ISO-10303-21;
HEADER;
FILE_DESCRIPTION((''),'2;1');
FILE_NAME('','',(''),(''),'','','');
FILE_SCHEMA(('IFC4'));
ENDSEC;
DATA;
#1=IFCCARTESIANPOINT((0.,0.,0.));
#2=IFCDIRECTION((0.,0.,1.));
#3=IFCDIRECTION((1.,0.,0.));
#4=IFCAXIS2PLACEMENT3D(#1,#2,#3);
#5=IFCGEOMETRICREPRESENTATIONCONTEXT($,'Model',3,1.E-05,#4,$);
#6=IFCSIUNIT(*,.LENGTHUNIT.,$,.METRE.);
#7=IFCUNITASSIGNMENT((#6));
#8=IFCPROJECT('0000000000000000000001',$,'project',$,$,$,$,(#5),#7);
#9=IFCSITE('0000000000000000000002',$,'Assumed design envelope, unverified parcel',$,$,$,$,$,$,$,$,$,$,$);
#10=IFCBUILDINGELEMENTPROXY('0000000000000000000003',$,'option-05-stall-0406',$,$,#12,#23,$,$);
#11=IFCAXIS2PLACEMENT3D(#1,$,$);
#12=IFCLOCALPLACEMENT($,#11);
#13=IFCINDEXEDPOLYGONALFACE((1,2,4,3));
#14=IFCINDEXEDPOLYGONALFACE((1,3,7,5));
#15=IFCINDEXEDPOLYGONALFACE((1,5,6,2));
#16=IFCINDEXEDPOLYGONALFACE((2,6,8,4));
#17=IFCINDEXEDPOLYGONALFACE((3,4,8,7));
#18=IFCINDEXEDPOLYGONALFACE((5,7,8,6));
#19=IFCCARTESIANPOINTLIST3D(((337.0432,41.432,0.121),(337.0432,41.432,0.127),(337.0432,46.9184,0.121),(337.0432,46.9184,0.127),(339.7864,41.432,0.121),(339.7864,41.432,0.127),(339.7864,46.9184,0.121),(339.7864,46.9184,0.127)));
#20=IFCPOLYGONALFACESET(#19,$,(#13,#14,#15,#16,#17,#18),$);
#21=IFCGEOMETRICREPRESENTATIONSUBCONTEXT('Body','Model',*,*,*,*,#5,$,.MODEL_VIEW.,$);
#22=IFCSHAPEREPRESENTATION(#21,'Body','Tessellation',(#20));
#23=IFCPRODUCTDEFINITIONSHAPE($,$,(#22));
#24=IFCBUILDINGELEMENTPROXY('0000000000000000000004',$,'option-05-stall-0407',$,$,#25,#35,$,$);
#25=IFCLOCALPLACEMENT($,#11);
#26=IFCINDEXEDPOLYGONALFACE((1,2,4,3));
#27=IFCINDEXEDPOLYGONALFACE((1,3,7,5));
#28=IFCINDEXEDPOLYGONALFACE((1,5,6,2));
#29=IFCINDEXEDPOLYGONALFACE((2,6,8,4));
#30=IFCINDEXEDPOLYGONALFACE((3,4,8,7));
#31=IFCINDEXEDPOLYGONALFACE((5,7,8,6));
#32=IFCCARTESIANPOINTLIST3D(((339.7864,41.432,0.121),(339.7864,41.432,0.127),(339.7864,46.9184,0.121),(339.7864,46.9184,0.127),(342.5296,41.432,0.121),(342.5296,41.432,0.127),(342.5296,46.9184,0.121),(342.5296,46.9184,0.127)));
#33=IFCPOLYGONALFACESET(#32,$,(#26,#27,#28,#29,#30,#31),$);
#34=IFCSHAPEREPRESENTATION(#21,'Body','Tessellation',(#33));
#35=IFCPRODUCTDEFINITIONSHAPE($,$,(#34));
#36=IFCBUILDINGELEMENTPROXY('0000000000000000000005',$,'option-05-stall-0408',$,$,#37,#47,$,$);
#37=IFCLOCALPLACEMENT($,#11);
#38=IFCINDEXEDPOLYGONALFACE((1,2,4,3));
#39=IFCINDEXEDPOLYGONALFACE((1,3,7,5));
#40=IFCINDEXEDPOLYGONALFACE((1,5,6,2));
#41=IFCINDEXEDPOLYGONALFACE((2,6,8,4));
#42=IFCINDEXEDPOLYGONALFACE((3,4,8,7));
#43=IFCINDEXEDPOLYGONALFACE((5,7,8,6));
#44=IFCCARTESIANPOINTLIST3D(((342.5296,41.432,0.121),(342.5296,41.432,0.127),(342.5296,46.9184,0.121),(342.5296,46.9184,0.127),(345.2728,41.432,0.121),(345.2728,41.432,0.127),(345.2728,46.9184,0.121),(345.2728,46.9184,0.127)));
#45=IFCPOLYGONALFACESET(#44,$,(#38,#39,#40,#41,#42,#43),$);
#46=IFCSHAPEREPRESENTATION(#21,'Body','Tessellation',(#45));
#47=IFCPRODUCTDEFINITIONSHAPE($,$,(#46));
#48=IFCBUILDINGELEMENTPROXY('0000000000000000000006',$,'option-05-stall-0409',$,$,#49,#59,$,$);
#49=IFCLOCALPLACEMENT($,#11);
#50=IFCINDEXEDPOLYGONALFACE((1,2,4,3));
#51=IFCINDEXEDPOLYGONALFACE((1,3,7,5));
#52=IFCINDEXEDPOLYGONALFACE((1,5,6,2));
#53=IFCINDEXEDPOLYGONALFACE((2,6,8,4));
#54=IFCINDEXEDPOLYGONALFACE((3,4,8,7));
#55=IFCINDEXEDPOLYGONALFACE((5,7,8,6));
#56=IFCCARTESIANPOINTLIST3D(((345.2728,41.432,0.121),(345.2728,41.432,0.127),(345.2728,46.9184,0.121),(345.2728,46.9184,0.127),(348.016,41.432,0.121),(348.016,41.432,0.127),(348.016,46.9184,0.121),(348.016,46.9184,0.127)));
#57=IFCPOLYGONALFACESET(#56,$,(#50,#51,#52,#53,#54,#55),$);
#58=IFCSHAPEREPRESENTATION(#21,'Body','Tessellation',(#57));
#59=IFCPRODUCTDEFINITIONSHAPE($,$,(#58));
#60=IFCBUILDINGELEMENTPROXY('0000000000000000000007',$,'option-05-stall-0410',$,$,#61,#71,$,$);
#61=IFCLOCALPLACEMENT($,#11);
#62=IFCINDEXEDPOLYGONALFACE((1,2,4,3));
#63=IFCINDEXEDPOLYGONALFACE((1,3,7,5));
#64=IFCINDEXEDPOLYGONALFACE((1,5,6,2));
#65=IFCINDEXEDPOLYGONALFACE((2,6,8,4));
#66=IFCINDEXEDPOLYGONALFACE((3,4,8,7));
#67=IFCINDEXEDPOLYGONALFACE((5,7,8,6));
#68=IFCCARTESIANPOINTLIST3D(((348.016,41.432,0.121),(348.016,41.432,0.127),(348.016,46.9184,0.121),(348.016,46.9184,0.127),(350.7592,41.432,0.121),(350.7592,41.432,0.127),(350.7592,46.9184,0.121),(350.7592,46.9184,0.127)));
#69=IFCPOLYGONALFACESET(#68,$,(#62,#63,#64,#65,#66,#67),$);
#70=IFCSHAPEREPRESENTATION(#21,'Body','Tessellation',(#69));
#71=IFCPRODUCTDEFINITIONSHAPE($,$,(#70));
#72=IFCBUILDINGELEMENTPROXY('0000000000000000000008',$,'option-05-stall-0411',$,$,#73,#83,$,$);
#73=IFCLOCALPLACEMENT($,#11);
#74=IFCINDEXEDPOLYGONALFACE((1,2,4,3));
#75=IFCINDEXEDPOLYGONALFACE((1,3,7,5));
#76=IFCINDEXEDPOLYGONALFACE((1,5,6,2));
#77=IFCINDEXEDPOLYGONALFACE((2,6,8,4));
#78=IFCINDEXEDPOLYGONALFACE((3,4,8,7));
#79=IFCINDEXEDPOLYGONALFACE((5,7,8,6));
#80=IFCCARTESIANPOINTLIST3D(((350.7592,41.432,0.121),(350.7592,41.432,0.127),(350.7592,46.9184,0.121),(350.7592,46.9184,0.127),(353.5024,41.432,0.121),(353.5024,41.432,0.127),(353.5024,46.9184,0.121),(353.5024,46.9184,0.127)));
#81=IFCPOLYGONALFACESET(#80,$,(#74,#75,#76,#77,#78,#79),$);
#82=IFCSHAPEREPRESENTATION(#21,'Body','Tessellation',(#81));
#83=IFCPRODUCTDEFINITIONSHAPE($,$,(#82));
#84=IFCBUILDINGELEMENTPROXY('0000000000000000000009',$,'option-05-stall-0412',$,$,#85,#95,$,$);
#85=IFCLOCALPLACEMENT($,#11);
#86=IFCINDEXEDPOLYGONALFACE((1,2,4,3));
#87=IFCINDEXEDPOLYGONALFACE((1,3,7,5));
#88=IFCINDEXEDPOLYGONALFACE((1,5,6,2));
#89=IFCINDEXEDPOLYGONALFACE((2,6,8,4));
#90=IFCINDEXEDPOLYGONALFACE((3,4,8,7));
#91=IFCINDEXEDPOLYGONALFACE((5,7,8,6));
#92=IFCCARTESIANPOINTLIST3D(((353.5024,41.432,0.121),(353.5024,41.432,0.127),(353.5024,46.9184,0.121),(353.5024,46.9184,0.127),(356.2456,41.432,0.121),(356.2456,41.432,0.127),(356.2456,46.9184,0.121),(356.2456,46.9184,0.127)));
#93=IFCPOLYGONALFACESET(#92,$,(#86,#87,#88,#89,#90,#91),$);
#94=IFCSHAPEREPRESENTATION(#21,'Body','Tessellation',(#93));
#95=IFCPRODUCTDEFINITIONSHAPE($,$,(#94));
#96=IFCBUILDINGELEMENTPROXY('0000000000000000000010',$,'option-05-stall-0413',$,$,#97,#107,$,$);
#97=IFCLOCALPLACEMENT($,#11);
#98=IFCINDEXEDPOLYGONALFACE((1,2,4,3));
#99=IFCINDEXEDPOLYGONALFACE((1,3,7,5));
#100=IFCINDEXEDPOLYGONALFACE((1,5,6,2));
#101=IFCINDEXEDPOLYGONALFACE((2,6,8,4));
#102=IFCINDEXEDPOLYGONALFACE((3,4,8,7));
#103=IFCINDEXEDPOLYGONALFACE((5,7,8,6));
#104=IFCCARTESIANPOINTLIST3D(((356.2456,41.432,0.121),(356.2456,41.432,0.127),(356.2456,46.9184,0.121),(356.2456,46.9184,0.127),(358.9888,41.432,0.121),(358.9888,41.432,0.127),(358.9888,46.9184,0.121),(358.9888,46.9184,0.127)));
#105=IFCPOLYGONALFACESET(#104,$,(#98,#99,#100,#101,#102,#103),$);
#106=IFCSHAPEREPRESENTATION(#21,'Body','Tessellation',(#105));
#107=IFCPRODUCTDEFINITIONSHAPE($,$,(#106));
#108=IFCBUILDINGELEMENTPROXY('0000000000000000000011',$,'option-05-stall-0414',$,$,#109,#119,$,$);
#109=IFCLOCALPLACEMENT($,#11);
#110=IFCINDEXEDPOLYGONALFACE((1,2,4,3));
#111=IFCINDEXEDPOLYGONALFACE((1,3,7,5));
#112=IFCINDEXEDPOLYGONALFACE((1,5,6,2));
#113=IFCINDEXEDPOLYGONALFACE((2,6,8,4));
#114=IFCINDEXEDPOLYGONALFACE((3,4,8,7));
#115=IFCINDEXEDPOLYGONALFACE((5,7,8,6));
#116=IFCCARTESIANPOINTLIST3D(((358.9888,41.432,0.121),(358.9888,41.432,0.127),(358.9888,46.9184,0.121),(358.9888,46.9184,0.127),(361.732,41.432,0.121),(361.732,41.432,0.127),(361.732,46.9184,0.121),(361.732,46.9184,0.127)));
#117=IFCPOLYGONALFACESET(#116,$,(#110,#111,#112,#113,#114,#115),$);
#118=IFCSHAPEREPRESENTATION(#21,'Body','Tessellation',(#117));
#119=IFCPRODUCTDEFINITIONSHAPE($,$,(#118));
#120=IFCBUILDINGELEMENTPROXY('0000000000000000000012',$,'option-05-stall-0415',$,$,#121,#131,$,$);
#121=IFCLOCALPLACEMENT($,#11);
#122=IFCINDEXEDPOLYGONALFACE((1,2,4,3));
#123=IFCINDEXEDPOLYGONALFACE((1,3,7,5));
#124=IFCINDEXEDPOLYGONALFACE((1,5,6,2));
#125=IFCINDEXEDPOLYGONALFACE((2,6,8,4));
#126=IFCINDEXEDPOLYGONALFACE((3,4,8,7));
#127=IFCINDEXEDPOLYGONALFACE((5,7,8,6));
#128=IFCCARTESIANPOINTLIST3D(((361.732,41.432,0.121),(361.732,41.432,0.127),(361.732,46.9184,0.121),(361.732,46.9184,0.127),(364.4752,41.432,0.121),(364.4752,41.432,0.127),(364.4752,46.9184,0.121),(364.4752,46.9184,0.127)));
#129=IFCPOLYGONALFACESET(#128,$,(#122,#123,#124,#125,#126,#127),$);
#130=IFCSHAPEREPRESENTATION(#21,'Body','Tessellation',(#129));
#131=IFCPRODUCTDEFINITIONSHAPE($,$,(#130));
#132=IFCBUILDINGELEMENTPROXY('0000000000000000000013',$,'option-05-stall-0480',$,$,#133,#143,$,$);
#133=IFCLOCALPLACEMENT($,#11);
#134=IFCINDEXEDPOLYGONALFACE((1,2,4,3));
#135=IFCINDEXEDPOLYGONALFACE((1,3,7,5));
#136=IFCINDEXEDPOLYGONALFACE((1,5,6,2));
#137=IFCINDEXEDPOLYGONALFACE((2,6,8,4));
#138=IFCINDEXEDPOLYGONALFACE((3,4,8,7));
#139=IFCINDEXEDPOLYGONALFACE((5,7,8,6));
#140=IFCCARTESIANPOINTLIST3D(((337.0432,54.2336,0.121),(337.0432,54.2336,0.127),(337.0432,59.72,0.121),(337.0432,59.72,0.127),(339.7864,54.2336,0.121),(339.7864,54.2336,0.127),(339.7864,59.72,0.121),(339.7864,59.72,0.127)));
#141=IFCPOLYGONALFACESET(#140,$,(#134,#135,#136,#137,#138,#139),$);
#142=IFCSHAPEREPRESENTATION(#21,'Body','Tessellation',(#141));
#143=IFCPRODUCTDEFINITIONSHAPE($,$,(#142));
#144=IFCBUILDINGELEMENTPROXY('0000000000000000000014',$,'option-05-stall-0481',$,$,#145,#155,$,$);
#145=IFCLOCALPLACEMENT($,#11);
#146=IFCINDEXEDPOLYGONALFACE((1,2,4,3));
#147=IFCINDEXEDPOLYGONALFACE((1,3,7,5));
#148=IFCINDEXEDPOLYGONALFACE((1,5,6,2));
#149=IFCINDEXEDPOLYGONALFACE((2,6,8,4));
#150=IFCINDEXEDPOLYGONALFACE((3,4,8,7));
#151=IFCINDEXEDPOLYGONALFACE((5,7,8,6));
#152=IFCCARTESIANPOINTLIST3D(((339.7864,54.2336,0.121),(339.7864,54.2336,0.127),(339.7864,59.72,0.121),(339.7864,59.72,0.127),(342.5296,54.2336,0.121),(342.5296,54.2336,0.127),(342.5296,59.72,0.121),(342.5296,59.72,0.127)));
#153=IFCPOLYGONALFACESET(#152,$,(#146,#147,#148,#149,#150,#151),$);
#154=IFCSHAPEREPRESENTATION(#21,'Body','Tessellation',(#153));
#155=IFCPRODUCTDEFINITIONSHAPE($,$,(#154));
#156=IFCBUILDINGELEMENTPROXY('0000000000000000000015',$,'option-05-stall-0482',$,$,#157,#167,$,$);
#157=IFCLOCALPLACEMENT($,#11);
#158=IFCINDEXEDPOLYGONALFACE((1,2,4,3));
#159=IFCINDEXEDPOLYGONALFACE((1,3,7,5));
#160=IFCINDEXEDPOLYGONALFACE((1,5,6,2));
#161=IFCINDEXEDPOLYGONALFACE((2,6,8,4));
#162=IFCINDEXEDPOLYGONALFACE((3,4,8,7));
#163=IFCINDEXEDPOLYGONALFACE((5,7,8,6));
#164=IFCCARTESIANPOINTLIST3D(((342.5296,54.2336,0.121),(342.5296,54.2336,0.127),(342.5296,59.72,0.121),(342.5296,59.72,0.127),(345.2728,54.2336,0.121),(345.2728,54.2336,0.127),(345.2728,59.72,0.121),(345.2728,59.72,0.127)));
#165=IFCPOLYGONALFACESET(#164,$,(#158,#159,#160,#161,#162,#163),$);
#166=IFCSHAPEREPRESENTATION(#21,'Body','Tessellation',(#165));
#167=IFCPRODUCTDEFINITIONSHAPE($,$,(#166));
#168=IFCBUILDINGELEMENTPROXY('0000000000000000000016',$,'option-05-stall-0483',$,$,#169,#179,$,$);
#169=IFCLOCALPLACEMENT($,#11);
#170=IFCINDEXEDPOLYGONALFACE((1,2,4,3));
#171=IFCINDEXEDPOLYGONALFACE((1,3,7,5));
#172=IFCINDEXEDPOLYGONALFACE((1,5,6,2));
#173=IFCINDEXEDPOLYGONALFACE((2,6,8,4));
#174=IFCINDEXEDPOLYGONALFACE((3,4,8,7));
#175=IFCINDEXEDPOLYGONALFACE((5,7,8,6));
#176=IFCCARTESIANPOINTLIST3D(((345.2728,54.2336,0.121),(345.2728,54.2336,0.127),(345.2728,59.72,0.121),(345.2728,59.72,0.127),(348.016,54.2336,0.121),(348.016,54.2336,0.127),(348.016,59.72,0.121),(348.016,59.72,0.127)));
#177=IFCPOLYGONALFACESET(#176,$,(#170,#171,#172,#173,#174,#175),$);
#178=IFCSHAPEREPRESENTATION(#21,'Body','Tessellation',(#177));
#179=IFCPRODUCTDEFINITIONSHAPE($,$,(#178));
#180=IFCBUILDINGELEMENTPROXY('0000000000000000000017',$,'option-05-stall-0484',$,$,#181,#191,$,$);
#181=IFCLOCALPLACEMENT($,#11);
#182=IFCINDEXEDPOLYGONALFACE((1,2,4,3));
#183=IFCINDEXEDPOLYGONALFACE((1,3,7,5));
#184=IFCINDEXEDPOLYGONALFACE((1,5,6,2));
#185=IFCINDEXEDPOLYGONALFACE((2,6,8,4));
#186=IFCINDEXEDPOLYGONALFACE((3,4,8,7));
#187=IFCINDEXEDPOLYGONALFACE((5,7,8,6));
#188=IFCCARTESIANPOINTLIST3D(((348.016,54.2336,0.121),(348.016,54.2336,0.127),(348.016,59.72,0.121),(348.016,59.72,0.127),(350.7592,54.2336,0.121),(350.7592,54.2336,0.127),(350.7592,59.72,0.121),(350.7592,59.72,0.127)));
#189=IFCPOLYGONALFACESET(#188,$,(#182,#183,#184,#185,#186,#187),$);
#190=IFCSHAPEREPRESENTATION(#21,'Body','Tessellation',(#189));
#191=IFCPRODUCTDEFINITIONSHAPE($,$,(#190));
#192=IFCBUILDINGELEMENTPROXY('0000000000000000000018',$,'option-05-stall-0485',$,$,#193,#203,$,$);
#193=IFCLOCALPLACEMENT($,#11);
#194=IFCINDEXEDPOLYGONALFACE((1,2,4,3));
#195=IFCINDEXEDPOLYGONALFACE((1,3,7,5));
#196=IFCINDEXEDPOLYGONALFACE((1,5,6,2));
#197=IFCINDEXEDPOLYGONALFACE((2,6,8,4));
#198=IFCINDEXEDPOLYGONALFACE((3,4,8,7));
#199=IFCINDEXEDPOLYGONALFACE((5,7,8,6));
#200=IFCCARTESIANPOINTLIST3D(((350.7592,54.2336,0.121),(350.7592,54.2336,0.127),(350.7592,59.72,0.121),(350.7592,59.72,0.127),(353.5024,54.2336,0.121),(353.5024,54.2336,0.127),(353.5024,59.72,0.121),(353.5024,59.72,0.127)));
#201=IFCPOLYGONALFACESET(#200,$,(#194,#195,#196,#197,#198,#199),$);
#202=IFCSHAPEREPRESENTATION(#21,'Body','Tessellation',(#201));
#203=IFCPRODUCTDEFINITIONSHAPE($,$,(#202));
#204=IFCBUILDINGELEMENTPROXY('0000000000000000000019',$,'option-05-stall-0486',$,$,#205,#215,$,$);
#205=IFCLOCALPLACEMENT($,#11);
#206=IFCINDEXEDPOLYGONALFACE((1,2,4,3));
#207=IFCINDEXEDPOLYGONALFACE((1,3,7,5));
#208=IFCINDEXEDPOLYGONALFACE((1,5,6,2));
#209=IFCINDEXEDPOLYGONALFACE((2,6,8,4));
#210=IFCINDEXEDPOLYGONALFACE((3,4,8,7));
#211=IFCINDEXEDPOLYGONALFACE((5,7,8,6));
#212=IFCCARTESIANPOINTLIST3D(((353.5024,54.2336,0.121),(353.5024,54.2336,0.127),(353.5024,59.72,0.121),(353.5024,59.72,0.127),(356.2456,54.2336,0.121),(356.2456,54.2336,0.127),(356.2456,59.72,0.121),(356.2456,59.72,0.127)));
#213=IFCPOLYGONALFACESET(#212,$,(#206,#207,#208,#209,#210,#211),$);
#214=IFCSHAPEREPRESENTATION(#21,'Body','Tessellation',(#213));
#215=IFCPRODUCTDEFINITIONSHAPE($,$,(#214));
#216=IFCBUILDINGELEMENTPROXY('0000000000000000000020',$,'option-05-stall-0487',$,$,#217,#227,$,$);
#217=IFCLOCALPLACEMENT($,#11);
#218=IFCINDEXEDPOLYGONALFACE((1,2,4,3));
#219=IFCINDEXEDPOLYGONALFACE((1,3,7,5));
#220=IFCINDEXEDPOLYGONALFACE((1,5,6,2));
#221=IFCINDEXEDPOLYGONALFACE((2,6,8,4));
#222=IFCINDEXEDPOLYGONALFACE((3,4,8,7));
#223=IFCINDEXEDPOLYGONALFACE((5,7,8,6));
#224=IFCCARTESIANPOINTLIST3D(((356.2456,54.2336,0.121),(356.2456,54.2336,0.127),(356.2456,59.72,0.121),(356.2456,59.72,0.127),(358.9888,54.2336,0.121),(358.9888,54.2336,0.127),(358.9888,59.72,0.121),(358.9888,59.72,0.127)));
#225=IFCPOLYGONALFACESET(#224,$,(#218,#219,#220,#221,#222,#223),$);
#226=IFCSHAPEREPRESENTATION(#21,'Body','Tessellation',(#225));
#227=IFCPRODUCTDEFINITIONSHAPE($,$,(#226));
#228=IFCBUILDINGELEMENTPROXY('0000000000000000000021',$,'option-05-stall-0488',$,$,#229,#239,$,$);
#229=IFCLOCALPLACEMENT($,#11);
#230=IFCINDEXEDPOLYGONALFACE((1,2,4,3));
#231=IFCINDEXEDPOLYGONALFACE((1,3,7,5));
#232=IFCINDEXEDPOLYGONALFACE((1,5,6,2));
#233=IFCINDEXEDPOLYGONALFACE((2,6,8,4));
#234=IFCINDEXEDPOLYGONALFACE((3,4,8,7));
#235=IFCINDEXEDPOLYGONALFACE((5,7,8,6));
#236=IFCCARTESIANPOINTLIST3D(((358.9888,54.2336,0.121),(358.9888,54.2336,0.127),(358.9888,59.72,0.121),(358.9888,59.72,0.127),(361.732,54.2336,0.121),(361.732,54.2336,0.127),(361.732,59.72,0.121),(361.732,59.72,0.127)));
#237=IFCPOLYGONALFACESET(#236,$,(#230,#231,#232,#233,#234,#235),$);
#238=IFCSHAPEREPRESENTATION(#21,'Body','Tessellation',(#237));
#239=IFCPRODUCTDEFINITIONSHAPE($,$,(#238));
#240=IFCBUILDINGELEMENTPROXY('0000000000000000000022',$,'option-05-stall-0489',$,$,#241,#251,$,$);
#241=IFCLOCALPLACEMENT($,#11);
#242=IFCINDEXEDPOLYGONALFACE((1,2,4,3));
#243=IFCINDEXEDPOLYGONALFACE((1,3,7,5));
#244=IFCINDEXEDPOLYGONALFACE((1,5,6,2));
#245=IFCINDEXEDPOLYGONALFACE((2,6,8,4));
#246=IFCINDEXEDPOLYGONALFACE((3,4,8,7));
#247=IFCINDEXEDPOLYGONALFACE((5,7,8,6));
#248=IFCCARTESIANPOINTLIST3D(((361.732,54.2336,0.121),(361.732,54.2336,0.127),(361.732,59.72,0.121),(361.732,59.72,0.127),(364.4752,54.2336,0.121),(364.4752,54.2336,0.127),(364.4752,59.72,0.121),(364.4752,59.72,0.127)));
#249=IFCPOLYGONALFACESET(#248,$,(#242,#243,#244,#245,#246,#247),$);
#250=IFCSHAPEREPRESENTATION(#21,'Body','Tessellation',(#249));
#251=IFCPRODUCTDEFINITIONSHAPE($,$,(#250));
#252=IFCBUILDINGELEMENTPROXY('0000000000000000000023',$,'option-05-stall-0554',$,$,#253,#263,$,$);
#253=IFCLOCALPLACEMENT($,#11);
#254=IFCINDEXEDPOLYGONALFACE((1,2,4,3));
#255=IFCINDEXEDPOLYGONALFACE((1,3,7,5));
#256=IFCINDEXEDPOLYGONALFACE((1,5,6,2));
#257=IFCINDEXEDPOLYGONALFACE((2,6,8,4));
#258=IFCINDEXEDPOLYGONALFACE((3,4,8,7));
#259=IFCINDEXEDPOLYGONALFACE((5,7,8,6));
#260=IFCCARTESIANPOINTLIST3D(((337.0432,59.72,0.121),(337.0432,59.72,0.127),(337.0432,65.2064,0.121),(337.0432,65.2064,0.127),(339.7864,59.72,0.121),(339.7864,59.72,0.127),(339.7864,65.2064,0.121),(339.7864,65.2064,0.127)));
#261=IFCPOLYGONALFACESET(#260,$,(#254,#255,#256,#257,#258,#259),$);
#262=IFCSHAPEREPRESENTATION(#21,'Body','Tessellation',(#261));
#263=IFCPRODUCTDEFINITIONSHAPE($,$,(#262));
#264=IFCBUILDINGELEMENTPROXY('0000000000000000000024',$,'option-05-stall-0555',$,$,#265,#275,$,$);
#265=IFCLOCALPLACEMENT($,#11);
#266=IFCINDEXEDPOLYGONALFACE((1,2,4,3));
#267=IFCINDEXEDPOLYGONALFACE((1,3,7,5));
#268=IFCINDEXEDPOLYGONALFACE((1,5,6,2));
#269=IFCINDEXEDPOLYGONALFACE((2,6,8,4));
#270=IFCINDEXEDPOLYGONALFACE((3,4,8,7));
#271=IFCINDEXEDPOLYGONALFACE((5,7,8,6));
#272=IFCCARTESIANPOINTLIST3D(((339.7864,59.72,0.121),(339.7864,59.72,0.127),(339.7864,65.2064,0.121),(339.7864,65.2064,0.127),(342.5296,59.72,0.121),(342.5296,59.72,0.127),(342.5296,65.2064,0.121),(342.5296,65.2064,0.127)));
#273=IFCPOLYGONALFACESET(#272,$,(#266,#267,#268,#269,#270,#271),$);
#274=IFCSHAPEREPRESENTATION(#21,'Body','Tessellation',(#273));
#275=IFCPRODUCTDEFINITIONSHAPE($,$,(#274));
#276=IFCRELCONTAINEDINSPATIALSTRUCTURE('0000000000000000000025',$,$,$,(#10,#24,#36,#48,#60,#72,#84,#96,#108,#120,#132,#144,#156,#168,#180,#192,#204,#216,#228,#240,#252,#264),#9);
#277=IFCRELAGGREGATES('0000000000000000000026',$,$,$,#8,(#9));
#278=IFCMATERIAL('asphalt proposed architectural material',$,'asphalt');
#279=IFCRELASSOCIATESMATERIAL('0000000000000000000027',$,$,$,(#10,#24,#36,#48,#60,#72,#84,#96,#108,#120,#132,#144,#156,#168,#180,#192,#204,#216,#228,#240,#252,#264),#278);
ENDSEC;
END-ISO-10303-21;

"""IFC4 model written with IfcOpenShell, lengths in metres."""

from ifc_helpers import new_model, si_unit, frame, origin_with_axes, place, context, subcontext, project, spatial, rectangle, extrude, material, element, save


model = new_model("IFC4")

# Units and contexts
model_context = context("Model", 3, precision=1e-05, world=origin_with_axes())
body_context = subcontext(model_context, "Body", "Model", "MODEL_VIEW")
ifc_project = project(units=[si_unit("LENGTHUNIT", "METRE")], contexts=[model_context])

# Site
site = spatial("IfcSite", under=ifc_project, Name="Assumed design envelope, unverified parcel")

# Building element proxies
ifc_material = material(Name="asphalt proposed architectural material", Category="asphalt")
for number, where, z_axis, x_axis, name in (
    (1, (338.4148, 44.1752, 0.121), (0.0, 0.0, 1.0), (1.0, 0.0, 0.0), "option-05-stall-0406"),
    (2, (341.158, 44.1752, 0.121), (0.0, 0.0, 1.0), (1.0, 0.0, 0.0), "option-05-stall-0407"),
    (3, (343.9012, 44.1752, 0.121), (0.0, 0.0, 1.0), (1.0, 0.0, 0.0), "option-05-stall-0408"),
    (4, (346.6444, 44.1752, 0.121), (0.0, 0.0, 1.0), (1.0, 0.0, 0.0), "option-05-stall-0409"),
    (5, (349.3876, 44.1752, 0.121), (0.0, 0.0, 1.0), (1.0, 0.0, 0.0), "option-05-stall-0410"),
    (6, (352.1308, 44.1752, 0.121), (0.0, 0.0, 1.0), (1.0, 0.0, 0.0), "option-05-stall-0411"),
    (7, (354.874, 44.1752, 0.121), (0.0, 0.0, 1.0), (1.0, 0.0, 0.0), "option-05-stall-0412"),
    (8, (357.6172, 44.1752, 0.121), (0.0, 0.0, 1.0), (1.0, 0.0, 0.0), "option-05-stall-0413"),
    (9, (360.3604, 44.1752, 0.121), (0.0, 0.0, 1.0), (1.0, 0.0, 0.0), "option-05-stall-0414"),
    (10, (363.1036, 44.1752, 0.121), (0.0, 0.0, 1.0), (1.0, 0.0, 0.0), "option-05-stall-0415"),
    (11, (338.4148, 56.9768, 0.121), (0.0, 0.0, 1.0), (1.0, 0.0, 0.0), "option-05-stall-0480"),
    (12, (341.158, 56.9768, 0.121), (0.0, 0.0, 1.0), (1.0, 0.0, 0.0), "option-05-stall-0481"),
    (13, (343.9012, 56.9768, 0.121), (0.0, 0.0, 1.0), (1.0, 0.0, 0.0), "option-05-stall-0482"),
    (14, (346.6444, 56.9768, 0.121), (0.0, 0.0, 1.0), (1.0, 0.0, 0.0), "option-05-stall-0483"),
    (15, (349.3876, 56.9768, 0.121), (0.0, 0.0, 1.0), (1.0, 0.0, 0.0), "option-05-stall-0484"),
    (16, (352.1308, 56.9768, 0.121), (0.0, 0.0, 1.0), (1.0, 0.0, 0.0), "option-05-stall-0485"),
    (17, (354.874, 56.9768, 0.121), (0.0, 0.0, 1.0), (1.0, 0.0, 0.0), "option-05-stall-0486"),
    (18, (357.6172, 56.9768, 0.121), (0.0, 0.0, 1.0), (1.0, 0.0, 0.0), "option-05-stall-0487"),
    (19, (360.3604, 56.9768, 0.121), (0.0, 0.0, 1.0), (1.0, 0.0, 0.0), "option-05-stall-0488"),
    (20, (363.1036, 56.9768, 0.121), (0.0, 0.0, 1.0), (1.0, 0.0, 0.0), "option-05-stall-0489"),
    (21, (338.4148, 62.4632, 0.121), (0.0, 0.0, 1.0), (1.0, 0.0, 0.0), "option-05-stall-0554"),
    (22, (341.158, 62.4632, 0.121), (0.0, 0.0, 1.0), (1.0, 0.0, 0.0), "option-05-stall-0555"),
):
    element("IfcBuildingElementProxy", number, at=place(None, frame(where, z_axis=z_axis, x_axis=x_axis)), inside=site, material=ifc_material, Name=name, context=body_context, shape_type="SweptSolid", body=[
        extrude(rectangle(XDim=2.7432, YDim=5.4864), origin_with_axes(), (0.0, 0.0, 1.0), 0.006),
    ])

save(model, "model.ifc")
